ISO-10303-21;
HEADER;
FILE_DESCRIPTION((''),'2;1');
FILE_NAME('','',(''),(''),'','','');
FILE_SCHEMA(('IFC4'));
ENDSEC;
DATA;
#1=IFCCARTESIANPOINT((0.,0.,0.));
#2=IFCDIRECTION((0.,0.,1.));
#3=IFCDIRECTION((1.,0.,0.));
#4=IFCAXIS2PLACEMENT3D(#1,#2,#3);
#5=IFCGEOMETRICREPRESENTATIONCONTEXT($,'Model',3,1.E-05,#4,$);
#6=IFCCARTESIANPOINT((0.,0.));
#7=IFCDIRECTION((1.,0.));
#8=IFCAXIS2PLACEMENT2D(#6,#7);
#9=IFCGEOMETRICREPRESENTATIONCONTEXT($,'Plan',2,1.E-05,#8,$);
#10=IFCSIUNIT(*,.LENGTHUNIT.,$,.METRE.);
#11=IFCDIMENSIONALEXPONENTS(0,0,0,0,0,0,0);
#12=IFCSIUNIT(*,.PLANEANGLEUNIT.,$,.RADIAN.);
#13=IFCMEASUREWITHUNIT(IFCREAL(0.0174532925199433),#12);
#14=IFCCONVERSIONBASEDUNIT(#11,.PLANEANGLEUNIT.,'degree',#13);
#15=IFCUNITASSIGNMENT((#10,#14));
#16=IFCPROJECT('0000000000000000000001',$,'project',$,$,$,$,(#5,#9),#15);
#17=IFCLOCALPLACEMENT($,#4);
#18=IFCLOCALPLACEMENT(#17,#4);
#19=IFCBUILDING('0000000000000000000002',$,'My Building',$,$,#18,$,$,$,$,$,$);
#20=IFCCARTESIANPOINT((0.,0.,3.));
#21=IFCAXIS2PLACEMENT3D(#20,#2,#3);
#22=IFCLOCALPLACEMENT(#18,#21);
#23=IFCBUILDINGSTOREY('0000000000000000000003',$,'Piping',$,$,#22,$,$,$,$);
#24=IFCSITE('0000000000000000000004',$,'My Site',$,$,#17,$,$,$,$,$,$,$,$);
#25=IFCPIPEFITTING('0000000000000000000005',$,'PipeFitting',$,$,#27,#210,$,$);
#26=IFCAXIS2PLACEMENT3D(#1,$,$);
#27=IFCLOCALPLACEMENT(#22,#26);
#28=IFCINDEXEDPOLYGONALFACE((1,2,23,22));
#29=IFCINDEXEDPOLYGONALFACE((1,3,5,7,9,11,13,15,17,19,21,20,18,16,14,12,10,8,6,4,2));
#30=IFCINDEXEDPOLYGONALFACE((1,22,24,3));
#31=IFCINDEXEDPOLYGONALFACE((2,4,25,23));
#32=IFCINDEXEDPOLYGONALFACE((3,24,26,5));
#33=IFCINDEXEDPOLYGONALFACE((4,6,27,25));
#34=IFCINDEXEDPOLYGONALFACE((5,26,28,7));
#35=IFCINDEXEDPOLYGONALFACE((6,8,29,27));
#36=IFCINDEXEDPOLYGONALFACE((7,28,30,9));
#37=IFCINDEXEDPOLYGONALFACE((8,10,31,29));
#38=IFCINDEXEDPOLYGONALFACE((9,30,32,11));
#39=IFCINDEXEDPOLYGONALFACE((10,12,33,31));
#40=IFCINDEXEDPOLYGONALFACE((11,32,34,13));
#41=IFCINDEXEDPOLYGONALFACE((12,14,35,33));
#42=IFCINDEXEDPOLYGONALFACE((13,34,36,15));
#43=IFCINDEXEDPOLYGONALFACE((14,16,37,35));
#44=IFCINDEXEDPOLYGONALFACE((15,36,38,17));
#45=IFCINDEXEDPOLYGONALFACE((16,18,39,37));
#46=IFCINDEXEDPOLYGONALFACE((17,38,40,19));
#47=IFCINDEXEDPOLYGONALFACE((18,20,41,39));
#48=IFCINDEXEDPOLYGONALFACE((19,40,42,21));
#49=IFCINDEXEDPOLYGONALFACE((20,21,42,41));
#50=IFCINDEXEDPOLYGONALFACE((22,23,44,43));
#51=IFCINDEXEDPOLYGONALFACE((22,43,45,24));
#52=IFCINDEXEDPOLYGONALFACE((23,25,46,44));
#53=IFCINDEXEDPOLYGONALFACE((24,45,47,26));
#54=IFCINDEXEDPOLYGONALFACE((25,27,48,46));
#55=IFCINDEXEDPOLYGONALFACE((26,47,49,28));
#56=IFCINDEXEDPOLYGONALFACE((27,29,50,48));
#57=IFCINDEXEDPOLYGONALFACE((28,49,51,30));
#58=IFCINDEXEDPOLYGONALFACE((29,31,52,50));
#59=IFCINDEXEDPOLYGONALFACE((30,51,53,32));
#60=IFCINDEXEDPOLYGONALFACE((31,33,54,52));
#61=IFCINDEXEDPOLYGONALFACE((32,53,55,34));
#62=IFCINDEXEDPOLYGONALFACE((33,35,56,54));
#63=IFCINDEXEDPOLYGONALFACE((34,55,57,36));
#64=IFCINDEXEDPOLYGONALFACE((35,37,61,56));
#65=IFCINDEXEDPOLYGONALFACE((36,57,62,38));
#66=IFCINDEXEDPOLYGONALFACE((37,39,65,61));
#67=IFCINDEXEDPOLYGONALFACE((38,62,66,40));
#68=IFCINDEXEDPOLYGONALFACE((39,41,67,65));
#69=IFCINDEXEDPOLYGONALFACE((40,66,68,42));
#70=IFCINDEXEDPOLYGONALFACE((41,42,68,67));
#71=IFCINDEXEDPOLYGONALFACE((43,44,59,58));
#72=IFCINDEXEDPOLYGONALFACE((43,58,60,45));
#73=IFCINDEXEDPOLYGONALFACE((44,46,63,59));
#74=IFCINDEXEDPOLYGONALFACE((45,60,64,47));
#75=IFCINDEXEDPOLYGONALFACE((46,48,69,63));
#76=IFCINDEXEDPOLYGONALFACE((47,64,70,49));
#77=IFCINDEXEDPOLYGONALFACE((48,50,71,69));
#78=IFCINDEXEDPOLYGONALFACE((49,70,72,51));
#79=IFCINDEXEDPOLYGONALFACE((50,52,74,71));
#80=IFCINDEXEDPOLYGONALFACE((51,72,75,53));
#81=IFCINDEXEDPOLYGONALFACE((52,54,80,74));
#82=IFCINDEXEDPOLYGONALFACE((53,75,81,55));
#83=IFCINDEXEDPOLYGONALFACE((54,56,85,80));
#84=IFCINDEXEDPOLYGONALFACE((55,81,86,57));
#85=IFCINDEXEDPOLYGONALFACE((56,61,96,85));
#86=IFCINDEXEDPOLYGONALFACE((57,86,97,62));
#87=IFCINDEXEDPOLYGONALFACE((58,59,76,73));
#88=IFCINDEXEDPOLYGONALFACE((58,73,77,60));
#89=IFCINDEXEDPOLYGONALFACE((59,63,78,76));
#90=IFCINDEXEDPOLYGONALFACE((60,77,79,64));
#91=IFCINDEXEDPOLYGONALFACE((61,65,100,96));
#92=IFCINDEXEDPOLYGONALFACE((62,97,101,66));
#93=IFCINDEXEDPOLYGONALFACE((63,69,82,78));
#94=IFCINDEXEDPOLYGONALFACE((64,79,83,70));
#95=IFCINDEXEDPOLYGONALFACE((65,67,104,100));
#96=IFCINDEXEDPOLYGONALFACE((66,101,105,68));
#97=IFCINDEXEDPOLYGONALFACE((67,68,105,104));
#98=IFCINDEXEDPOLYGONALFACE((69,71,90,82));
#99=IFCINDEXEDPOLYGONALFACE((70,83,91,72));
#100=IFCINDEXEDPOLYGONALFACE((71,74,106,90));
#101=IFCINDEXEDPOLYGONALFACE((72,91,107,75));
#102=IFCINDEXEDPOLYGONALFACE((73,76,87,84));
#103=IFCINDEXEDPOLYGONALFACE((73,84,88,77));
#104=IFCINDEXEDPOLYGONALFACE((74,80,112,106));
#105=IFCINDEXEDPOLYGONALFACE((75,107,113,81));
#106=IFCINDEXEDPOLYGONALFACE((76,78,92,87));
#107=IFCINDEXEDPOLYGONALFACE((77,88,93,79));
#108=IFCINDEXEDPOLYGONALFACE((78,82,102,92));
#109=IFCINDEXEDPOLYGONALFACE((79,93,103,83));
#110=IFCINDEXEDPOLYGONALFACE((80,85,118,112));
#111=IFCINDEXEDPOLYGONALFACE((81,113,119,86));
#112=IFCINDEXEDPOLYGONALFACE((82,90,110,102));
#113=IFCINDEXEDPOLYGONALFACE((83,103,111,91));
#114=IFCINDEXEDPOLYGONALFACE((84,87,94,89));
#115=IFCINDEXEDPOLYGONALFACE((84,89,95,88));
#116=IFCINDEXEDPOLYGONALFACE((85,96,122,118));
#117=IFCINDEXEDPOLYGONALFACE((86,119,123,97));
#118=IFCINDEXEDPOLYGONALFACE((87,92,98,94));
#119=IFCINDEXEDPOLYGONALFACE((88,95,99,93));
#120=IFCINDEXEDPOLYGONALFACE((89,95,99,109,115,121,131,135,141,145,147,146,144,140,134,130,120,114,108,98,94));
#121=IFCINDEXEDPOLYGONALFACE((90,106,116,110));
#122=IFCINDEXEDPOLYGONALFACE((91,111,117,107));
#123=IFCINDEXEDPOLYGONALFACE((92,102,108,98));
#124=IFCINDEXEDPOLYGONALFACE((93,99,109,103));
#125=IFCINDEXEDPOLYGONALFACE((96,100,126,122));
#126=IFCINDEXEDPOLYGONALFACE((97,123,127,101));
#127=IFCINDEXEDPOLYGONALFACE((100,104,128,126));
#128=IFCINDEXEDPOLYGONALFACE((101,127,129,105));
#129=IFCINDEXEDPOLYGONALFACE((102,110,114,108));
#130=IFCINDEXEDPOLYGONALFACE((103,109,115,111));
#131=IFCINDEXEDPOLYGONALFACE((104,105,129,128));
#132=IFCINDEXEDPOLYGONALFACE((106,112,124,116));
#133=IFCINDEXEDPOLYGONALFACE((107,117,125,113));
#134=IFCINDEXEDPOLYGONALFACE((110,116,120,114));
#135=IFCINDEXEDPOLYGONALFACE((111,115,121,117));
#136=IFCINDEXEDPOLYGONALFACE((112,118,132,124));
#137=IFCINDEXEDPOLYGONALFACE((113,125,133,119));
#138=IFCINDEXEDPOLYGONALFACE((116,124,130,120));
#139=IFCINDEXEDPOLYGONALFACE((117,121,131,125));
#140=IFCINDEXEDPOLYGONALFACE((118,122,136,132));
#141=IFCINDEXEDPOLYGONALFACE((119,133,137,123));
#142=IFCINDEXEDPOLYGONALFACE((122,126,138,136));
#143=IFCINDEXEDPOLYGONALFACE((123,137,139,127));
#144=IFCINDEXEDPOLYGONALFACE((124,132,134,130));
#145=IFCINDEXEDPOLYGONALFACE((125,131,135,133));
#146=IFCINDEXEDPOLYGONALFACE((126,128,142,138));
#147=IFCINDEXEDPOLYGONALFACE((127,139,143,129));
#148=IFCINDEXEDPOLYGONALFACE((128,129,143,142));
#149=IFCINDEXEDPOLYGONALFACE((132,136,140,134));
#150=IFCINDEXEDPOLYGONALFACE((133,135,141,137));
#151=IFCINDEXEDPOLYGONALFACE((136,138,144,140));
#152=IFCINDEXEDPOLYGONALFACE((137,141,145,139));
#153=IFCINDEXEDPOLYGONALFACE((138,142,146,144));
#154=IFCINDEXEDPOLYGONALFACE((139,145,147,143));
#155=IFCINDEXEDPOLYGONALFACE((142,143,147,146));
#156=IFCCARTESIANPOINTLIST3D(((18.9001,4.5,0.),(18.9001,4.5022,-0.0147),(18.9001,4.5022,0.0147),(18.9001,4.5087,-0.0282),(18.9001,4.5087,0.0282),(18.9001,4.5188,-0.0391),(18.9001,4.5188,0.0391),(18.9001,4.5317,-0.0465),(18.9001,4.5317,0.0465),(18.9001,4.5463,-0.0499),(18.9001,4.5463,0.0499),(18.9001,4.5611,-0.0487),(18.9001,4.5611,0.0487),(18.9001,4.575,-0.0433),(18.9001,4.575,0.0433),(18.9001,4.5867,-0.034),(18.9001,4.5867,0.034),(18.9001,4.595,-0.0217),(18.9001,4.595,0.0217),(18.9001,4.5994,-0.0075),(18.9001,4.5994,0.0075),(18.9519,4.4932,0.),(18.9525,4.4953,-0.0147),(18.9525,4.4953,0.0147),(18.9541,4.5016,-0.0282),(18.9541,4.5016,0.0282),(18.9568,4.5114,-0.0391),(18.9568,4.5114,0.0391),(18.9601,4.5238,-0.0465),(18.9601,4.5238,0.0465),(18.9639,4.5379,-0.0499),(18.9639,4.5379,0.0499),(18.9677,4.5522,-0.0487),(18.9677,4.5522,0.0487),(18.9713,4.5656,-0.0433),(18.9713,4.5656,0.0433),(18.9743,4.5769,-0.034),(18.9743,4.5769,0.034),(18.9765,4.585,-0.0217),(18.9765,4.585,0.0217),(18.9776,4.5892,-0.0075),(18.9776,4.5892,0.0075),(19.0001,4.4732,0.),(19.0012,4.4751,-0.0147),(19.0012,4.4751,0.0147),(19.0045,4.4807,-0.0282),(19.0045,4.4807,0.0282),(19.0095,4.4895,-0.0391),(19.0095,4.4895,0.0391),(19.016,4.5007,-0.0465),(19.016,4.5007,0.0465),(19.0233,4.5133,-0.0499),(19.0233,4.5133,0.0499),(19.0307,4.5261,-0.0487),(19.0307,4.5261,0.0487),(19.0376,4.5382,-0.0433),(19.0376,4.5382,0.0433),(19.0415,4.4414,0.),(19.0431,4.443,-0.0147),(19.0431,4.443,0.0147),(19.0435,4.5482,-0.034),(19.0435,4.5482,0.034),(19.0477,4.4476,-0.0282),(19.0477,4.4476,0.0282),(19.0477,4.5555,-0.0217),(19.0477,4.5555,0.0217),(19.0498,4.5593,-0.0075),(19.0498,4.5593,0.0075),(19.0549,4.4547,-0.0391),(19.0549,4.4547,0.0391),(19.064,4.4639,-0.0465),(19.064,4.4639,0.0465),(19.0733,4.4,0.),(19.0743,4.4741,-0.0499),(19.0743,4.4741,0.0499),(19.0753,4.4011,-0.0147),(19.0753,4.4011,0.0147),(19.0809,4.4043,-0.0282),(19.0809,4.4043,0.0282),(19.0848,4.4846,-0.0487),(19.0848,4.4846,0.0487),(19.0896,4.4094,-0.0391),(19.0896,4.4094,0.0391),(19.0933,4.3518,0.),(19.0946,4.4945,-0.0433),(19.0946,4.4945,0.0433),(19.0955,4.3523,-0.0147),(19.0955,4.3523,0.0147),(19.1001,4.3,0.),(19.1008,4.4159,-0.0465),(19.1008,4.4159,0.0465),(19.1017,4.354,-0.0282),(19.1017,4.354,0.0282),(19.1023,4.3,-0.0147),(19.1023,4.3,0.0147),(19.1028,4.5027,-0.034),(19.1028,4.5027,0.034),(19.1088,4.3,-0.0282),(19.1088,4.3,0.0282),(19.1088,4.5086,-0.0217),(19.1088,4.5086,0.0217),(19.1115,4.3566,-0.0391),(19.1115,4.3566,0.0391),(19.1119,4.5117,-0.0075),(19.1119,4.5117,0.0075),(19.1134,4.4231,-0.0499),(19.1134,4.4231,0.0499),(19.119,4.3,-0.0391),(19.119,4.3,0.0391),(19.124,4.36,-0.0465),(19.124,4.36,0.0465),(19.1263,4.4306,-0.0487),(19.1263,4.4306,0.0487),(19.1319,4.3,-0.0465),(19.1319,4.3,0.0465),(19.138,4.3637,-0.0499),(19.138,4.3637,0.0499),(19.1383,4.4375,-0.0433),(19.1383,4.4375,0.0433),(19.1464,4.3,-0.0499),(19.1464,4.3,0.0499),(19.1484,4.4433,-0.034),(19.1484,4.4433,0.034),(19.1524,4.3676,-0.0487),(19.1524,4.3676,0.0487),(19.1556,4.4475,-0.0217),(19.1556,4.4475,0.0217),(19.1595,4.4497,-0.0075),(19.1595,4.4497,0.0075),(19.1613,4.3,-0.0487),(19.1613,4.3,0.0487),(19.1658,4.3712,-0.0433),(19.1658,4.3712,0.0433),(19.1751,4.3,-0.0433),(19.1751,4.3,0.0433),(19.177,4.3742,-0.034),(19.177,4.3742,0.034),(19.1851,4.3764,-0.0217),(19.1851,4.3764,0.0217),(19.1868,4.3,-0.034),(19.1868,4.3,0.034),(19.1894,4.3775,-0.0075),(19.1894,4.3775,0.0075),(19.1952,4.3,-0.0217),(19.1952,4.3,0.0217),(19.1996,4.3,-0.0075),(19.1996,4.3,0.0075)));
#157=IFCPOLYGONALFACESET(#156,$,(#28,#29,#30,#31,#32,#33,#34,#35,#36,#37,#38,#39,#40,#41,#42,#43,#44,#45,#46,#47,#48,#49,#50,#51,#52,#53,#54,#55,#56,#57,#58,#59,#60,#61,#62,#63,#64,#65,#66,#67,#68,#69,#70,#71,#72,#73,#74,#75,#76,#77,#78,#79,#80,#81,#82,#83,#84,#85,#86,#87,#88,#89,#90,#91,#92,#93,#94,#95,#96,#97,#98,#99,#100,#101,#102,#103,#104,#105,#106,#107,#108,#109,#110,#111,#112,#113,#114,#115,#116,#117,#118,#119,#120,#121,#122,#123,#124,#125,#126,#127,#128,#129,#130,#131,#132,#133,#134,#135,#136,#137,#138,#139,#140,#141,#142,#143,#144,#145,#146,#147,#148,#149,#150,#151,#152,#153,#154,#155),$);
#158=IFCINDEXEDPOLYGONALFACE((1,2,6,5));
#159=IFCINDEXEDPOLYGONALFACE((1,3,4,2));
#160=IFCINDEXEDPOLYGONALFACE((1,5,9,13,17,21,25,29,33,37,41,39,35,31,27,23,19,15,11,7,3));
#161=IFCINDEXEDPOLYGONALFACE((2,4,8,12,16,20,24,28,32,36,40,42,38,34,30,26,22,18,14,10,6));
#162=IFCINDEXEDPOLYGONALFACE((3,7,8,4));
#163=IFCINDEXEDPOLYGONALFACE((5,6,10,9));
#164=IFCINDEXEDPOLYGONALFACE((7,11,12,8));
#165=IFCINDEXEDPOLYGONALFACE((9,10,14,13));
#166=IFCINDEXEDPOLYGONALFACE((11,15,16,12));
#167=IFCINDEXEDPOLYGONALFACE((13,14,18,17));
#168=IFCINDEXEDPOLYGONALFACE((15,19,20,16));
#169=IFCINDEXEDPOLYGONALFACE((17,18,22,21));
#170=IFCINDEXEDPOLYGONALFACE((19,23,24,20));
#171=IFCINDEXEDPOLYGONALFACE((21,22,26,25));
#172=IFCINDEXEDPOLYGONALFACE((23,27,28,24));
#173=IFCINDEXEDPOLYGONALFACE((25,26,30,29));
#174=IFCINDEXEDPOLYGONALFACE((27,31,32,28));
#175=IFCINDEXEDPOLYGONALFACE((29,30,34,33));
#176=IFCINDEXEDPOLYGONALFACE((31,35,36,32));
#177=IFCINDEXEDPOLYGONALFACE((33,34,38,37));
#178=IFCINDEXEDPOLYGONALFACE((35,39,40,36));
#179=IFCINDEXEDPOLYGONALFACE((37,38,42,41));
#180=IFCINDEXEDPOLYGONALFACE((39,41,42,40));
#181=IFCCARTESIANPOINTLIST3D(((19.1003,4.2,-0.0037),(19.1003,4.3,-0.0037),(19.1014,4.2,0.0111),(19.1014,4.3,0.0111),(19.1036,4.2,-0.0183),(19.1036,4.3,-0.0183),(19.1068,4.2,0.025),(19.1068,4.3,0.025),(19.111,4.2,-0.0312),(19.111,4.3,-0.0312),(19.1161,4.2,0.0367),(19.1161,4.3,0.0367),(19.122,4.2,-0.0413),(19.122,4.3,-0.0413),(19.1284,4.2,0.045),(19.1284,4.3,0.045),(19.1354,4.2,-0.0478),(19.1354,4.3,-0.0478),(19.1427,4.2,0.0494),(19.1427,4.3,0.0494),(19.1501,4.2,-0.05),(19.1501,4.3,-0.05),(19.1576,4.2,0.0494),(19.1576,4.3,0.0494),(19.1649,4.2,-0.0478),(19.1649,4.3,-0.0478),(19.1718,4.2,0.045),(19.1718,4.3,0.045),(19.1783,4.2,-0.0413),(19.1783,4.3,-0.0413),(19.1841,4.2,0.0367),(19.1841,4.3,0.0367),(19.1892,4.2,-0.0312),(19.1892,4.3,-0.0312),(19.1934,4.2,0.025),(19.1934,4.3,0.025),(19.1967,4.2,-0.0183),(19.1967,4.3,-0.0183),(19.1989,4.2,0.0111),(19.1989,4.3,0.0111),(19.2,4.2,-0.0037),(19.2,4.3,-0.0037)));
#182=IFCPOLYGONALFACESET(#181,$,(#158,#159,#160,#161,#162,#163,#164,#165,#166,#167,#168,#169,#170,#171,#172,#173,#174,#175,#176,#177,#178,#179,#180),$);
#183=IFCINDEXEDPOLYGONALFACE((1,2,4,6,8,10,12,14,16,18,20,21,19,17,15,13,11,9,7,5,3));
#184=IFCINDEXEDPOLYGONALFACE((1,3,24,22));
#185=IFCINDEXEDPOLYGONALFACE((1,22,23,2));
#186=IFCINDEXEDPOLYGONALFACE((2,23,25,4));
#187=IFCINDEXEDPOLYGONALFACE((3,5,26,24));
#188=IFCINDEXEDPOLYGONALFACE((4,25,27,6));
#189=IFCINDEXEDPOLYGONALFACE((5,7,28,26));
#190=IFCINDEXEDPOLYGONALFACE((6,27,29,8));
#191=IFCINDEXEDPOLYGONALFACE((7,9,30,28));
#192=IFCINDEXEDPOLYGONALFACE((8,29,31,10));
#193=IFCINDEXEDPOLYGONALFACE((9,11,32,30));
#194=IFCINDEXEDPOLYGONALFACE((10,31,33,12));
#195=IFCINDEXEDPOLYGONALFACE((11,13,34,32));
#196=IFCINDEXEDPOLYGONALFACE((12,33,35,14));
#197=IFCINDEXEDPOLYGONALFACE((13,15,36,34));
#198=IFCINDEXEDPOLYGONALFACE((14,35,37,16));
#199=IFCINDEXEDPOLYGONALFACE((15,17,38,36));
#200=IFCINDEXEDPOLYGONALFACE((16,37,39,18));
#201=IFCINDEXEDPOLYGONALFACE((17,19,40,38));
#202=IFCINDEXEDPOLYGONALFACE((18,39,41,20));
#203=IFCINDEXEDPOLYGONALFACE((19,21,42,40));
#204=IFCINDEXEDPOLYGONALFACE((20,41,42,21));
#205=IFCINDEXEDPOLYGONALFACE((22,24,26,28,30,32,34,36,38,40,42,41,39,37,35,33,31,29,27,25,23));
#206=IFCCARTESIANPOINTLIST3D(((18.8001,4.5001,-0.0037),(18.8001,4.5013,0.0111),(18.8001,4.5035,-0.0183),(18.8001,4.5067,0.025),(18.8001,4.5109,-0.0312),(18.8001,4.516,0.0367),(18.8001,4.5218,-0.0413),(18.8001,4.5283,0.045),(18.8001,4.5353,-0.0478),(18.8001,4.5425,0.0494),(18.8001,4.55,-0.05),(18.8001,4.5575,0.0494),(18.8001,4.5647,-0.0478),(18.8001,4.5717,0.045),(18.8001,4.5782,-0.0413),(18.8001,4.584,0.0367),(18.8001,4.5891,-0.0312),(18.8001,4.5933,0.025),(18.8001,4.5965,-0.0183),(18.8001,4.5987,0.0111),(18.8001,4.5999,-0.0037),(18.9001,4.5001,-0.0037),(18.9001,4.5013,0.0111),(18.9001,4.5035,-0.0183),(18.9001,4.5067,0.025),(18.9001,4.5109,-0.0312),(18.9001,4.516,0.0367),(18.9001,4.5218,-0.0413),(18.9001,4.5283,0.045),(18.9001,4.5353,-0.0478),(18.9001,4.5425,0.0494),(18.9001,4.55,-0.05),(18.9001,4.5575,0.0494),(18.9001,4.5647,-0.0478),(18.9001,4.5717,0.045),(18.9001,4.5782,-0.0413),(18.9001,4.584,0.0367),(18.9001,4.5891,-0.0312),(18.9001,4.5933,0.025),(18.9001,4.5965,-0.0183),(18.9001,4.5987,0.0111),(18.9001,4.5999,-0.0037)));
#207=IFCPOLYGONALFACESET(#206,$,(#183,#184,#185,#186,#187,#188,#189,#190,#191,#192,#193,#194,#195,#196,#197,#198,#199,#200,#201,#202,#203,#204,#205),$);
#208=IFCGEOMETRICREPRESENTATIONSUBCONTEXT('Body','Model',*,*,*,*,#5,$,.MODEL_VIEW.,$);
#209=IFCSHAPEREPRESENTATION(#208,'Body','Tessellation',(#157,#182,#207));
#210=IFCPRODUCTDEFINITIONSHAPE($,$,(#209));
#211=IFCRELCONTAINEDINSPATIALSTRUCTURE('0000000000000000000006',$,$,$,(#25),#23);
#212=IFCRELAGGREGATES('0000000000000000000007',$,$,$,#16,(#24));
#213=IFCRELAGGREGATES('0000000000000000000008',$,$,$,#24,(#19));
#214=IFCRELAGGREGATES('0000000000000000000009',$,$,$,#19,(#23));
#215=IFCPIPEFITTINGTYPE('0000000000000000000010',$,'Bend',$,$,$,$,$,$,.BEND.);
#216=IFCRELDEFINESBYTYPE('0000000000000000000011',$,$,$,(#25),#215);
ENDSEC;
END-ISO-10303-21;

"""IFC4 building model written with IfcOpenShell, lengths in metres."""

from ifc_helpers import new_model, entity, si_unit, converted_unit, frame, origin_with_axes, origin_2d_with_axis, place, context, subcontext, project, spatial, circle, extrude, source, transform, mapped, type_object, type_shapes, element, save


model = new_model("IFC4")

# Units and contexts
model_context = context("Model", 3, precision=1e-05, world=origin_with_axes())
plan_context = context("Plan", 2, precision=1e-05, world=origin_2d_with_axis())
body_context = subcontext(model_context, "Body", "Model", "MODEL_VIEW")
ifc_project = project(units=[si_unit("LENGTHUNIT", "METRE"), converted_unit("PLANEANGLEUNIT", "degree", entity("IfcReal", 0.0174532925199433), si_unit("PLANEANGLEUNIT", "RADIAN"), dimensions=[0, 0, 0, 0, 0, 0, 0])], contexts=[model_context, plan_context])

# Site, building, storey
site_placement = place(None, origin_with_axes())
site = spatial("IfcSite", under=ifc_project, at=site_placement, Name="My Site")
building_placement = place(site_placement, origin_with_axes())
building = spatial("IfcBuilding", under=site, at=building_placement, Name="My Building")
storey_placement = place(building_placement, frame((0.0, 0.0, 3.0), z_axis=(0.0, 0.0, 1.0), x_axis=(1.0, 0.0, 0.0)))
storey = spatial("IfcBuildingStorey", under=building, at=storey_placement, Name="Piping")

# Pipe fitting
pipe_fitting_type = type_object("IfcPipeFittingType", Name="Bend", PredefinedType="BEND")
shared_shape = source(origin_with_axes(), body_context, "Body", "SolidModel", [
    entity("IfcSweptDiskSolid", entity("IfcIndexedPolyCurve", entity("IfcCartesianPointList3D", [[0.0, 0.0, -0.1], [0.0, -0.0732, -0.2768], [0.0, -0.25, -0.35]]), [entity("IfcArcIndex", [1, 2, 3])]), 0.05),
    extrude(circle(Radius=0.05), origin_with_axes(), (0.0, 0.0, -1.0), 0.1),
    extrude(circle(Radius=0.05), frame((0.0, -0.25, -0.35), z_axis=(0.0, -1.0, 0.0), x_axis=(1.0, 0.0, 0.0)), (0.0, 0.0, 1.0), 0.1),
])
type_shapes(pipe_fitting_type, [shared_shape])
for number, where, z_axis, x_axis, name in (
    (1, (19.1501, 4.2, 0.0), (0.0, -1.0, 0.0), (0.0, 0.0, -1.0), "PipeFitting"),
):
    element("IfcPipeFitting", number, at=place(storey_placement, frame(where, z_axis=z_axis, x_axis=x_axis)), inside=storey, type_object=pipe_fitting_type, Name=name, context=body_context, shape_type="MappedRepresentation", body=[
        mapped(shared_shape, transform((0.0, 0.0, 0.0), x_axis=(1.0, 0.0, 0.0), y_axis=(0.0, 1.0, 0.0), z_axis=(0.0, 0.0, 1.0), scale=1.0)),
    ])

save(model, "model.ifc")
